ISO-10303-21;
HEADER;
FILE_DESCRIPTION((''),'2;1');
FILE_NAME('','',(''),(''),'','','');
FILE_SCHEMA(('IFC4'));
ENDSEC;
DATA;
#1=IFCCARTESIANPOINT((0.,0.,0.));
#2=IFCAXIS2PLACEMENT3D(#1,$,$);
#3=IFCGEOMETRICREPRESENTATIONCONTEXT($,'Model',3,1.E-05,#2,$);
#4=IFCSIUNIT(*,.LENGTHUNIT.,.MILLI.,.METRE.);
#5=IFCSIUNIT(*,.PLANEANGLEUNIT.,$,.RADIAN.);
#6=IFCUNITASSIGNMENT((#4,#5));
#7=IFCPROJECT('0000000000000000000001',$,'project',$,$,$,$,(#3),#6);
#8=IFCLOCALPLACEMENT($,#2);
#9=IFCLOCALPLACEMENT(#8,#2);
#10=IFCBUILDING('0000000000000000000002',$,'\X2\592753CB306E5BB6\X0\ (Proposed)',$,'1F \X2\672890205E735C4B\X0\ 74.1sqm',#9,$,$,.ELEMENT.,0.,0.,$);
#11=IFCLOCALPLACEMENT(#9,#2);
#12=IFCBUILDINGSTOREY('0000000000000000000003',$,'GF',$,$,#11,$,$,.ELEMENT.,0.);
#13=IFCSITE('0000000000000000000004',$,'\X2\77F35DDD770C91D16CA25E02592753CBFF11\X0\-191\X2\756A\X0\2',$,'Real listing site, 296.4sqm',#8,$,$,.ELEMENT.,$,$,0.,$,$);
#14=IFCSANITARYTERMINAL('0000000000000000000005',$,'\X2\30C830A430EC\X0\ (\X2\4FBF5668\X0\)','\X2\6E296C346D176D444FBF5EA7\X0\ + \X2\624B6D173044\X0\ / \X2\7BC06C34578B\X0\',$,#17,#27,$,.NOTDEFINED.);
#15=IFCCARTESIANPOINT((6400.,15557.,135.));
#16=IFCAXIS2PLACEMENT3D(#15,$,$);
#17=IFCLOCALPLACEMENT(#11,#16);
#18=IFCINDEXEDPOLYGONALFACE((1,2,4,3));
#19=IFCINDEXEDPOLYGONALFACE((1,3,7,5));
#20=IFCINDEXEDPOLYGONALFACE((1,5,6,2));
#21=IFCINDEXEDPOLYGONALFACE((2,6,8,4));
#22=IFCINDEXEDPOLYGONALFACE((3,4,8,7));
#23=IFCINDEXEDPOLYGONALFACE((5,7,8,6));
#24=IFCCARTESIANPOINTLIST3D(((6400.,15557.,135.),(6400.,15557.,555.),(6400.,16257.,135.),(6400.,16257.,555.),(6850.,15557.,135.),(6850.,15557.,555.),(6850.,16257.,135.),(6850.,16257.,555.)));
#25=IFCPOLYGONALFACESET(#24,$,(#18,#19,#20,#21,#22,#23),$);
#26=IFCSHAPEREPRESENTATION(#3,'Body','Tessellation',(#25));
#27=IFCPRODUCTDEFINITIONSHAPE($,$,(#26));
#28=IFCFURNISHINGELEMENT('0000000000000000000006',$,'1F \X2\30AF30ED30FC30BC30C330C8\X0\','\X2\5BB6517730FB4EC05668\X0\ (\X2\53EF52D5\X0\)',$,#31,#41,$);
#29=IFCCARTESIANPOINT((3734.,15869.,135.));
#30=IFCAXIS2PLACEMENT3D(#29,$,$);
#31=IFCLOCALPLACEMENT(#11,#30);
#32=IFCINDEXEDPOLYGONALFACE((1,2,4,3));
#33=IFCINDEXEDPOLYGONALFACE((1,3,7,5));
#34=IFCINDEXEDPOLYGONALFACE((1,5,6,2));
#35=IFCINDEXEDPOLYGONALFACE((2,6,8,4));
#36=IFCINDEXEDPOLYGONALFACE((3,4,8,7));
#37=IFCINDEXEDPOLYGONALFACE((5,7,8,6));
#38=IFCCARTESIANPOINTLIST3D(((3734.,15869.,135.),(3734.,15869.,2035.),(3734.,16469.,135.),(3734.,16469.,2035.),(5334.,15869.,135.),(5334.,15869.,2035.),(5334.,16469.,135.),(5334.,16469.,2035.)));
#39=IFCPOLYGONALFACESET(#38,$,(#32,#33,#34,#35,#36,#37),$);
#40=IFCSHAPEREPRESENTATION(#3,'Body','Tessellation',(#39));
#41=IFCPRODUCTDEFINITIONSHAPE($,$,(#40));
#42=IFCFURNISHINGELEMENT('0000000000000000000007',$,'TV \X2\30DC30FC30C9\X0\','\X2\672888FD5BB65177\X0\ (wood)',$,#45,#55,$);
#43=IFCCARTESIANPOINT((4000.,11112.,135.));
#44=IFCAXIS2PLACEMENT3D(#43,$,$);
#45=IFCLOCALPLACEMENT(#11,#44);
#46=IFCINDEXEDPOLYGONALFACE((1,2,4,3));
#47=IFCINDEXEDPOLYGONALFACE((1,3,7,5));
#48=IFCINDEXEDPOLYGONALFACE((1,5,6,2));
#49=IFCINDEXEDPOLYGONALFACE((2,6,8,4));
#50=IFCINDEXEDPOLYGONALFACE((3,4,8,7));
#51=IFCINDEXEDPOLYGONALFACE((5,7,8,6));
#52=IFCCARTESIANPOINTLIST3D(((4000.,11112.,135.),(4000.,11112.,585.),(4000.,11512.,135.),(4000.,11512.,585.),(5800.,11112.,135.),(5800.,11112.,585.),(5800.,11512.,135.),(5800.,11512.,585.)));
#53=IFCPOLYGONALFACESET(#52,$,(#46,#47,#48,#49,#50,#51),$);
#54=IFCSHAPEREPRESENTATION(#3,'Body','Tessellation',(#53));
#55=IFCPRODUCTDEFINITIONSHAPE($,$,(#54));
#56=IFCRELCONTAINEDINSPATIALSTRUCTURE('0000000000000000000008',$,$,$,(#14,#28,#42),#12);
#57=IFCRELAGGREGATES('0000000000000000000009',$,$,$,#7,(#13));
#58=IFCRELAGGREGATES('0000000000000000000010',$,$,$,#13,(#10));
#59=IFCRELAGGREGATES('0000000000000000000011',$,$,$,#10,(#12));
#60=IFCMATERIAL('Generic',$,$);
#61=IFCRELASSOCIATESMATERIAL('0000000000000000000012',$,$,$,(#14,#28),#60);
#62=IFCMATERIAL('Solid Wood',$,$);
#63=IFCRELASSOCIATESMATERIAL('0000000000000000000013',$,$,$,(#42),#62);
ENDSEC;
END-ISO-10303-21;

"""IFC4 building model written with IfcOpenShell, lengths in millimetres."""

from ifc_helpers import new_model, si_unit, frame, frame_2d, origin, place, context, project, spatial, rectangle, extrude, material, element, save


model = new_model("IFC4")

# Units and contexts
model_context = context("Model", 3, precision=1e-05, world=origin())
ifc_project = project(units=[si_unit("LENGTHUNIT", "METRE", prefix="MILLI"), si_unit("PLANEANGLEUNIT", "RADIAN")], contexts=[model_context])

# Site, building, storey
site_placement = place(None, origin())
site = spatial("IfcSite", under=ifc_project, at=site_placement, Name="石川県金沢市大友１-191番2", ObjectType="Real listing site, 296.4sqm", CompositionType="ELEMENT", RefElevation=0.0)
building_placement = place(site_placement, origin())
building = spatial("IfcBuilding", under=site, at=building_placement, Name="大友の家 (Proposed)", ObjectType="1F 木造平屋 74.1sqm", CompositionType="ELEMENT", ElevationOfRefHeight=0.0, ElevationOfTerrain=0.0)
storey_placement = place(building_placement, origin())
storey = spatial("IfcBuildingStorey", under=building, at=storey_placement, Name="GF", CompositionType="ELEMENT", Elevation=0.0)

# Shared definitions
ifc_material_1 = material(Name="Solid Wood")

# Shared definitions
ifc_material_2 = material(Name="Generic")

# Sanitary terminal
sanitary_terminal_1_placement = place(storey_placement, frame((6400.0, 15557.0, 135.0)))
element("IfcSanitaryTerminal", 1, at=sanitary_terminal_1_placement, inside=storey, material=ifc_material_2, Name="トイレ (便器)", Description="温水洗浄便座 + 手洗い / 節水型", PredefinedType="NOTDEFINED", context=model_context, shape_type="SweptSolid", body=[
    extrude(rectangle(XDim=450.0, YDim=700.0, at=frame_2d((225.0, 350.0))), frame((6400.0, 15557.0, 135.0)), (0.0, 0.0, 1.0), 420.0),
])

# Furnishing elements
furnishing_1_placement = place(storey_placement, frame((3734.0, 15869.0, 135.0)))
element("IfcFurnishingElement", 2, at=furnishing_1_placement, inside=storey, material=ifc_material_2, Name="1F クローゼット", Description="家具・什器 (可動)", context=model_context, shape_type="SweptSolid", body=[
    extrude(rectangle(XDim=1600.0, YDim=600.0, at=frame_2d((800.0, 300.0))), frame((3734.0, 15869.0, 135.0)), (0.0, 0.0, 1.0), 1900.0),
])
furnishing_2_placement = place(storey_placement, frame((4000.0, 11112.0, 135.0)))
element("IfcFurnishingElement", 3, at=furnishing_2_placement, inside=storey, material=ifc_material_1, Name="TV ボード", Description="木製家具 (wood)", context=model_context, shape_type="SweptSolid", body=[
    extrude(rectangle(XDim=1800.0, YDim=400.0, at=frame_2d((900.0, 200.0))), frame((4000.0, 11112.0, 135.0)), (0.0, 0.0, 1.0), 450.0),
])

save(model, "model.ifc")
